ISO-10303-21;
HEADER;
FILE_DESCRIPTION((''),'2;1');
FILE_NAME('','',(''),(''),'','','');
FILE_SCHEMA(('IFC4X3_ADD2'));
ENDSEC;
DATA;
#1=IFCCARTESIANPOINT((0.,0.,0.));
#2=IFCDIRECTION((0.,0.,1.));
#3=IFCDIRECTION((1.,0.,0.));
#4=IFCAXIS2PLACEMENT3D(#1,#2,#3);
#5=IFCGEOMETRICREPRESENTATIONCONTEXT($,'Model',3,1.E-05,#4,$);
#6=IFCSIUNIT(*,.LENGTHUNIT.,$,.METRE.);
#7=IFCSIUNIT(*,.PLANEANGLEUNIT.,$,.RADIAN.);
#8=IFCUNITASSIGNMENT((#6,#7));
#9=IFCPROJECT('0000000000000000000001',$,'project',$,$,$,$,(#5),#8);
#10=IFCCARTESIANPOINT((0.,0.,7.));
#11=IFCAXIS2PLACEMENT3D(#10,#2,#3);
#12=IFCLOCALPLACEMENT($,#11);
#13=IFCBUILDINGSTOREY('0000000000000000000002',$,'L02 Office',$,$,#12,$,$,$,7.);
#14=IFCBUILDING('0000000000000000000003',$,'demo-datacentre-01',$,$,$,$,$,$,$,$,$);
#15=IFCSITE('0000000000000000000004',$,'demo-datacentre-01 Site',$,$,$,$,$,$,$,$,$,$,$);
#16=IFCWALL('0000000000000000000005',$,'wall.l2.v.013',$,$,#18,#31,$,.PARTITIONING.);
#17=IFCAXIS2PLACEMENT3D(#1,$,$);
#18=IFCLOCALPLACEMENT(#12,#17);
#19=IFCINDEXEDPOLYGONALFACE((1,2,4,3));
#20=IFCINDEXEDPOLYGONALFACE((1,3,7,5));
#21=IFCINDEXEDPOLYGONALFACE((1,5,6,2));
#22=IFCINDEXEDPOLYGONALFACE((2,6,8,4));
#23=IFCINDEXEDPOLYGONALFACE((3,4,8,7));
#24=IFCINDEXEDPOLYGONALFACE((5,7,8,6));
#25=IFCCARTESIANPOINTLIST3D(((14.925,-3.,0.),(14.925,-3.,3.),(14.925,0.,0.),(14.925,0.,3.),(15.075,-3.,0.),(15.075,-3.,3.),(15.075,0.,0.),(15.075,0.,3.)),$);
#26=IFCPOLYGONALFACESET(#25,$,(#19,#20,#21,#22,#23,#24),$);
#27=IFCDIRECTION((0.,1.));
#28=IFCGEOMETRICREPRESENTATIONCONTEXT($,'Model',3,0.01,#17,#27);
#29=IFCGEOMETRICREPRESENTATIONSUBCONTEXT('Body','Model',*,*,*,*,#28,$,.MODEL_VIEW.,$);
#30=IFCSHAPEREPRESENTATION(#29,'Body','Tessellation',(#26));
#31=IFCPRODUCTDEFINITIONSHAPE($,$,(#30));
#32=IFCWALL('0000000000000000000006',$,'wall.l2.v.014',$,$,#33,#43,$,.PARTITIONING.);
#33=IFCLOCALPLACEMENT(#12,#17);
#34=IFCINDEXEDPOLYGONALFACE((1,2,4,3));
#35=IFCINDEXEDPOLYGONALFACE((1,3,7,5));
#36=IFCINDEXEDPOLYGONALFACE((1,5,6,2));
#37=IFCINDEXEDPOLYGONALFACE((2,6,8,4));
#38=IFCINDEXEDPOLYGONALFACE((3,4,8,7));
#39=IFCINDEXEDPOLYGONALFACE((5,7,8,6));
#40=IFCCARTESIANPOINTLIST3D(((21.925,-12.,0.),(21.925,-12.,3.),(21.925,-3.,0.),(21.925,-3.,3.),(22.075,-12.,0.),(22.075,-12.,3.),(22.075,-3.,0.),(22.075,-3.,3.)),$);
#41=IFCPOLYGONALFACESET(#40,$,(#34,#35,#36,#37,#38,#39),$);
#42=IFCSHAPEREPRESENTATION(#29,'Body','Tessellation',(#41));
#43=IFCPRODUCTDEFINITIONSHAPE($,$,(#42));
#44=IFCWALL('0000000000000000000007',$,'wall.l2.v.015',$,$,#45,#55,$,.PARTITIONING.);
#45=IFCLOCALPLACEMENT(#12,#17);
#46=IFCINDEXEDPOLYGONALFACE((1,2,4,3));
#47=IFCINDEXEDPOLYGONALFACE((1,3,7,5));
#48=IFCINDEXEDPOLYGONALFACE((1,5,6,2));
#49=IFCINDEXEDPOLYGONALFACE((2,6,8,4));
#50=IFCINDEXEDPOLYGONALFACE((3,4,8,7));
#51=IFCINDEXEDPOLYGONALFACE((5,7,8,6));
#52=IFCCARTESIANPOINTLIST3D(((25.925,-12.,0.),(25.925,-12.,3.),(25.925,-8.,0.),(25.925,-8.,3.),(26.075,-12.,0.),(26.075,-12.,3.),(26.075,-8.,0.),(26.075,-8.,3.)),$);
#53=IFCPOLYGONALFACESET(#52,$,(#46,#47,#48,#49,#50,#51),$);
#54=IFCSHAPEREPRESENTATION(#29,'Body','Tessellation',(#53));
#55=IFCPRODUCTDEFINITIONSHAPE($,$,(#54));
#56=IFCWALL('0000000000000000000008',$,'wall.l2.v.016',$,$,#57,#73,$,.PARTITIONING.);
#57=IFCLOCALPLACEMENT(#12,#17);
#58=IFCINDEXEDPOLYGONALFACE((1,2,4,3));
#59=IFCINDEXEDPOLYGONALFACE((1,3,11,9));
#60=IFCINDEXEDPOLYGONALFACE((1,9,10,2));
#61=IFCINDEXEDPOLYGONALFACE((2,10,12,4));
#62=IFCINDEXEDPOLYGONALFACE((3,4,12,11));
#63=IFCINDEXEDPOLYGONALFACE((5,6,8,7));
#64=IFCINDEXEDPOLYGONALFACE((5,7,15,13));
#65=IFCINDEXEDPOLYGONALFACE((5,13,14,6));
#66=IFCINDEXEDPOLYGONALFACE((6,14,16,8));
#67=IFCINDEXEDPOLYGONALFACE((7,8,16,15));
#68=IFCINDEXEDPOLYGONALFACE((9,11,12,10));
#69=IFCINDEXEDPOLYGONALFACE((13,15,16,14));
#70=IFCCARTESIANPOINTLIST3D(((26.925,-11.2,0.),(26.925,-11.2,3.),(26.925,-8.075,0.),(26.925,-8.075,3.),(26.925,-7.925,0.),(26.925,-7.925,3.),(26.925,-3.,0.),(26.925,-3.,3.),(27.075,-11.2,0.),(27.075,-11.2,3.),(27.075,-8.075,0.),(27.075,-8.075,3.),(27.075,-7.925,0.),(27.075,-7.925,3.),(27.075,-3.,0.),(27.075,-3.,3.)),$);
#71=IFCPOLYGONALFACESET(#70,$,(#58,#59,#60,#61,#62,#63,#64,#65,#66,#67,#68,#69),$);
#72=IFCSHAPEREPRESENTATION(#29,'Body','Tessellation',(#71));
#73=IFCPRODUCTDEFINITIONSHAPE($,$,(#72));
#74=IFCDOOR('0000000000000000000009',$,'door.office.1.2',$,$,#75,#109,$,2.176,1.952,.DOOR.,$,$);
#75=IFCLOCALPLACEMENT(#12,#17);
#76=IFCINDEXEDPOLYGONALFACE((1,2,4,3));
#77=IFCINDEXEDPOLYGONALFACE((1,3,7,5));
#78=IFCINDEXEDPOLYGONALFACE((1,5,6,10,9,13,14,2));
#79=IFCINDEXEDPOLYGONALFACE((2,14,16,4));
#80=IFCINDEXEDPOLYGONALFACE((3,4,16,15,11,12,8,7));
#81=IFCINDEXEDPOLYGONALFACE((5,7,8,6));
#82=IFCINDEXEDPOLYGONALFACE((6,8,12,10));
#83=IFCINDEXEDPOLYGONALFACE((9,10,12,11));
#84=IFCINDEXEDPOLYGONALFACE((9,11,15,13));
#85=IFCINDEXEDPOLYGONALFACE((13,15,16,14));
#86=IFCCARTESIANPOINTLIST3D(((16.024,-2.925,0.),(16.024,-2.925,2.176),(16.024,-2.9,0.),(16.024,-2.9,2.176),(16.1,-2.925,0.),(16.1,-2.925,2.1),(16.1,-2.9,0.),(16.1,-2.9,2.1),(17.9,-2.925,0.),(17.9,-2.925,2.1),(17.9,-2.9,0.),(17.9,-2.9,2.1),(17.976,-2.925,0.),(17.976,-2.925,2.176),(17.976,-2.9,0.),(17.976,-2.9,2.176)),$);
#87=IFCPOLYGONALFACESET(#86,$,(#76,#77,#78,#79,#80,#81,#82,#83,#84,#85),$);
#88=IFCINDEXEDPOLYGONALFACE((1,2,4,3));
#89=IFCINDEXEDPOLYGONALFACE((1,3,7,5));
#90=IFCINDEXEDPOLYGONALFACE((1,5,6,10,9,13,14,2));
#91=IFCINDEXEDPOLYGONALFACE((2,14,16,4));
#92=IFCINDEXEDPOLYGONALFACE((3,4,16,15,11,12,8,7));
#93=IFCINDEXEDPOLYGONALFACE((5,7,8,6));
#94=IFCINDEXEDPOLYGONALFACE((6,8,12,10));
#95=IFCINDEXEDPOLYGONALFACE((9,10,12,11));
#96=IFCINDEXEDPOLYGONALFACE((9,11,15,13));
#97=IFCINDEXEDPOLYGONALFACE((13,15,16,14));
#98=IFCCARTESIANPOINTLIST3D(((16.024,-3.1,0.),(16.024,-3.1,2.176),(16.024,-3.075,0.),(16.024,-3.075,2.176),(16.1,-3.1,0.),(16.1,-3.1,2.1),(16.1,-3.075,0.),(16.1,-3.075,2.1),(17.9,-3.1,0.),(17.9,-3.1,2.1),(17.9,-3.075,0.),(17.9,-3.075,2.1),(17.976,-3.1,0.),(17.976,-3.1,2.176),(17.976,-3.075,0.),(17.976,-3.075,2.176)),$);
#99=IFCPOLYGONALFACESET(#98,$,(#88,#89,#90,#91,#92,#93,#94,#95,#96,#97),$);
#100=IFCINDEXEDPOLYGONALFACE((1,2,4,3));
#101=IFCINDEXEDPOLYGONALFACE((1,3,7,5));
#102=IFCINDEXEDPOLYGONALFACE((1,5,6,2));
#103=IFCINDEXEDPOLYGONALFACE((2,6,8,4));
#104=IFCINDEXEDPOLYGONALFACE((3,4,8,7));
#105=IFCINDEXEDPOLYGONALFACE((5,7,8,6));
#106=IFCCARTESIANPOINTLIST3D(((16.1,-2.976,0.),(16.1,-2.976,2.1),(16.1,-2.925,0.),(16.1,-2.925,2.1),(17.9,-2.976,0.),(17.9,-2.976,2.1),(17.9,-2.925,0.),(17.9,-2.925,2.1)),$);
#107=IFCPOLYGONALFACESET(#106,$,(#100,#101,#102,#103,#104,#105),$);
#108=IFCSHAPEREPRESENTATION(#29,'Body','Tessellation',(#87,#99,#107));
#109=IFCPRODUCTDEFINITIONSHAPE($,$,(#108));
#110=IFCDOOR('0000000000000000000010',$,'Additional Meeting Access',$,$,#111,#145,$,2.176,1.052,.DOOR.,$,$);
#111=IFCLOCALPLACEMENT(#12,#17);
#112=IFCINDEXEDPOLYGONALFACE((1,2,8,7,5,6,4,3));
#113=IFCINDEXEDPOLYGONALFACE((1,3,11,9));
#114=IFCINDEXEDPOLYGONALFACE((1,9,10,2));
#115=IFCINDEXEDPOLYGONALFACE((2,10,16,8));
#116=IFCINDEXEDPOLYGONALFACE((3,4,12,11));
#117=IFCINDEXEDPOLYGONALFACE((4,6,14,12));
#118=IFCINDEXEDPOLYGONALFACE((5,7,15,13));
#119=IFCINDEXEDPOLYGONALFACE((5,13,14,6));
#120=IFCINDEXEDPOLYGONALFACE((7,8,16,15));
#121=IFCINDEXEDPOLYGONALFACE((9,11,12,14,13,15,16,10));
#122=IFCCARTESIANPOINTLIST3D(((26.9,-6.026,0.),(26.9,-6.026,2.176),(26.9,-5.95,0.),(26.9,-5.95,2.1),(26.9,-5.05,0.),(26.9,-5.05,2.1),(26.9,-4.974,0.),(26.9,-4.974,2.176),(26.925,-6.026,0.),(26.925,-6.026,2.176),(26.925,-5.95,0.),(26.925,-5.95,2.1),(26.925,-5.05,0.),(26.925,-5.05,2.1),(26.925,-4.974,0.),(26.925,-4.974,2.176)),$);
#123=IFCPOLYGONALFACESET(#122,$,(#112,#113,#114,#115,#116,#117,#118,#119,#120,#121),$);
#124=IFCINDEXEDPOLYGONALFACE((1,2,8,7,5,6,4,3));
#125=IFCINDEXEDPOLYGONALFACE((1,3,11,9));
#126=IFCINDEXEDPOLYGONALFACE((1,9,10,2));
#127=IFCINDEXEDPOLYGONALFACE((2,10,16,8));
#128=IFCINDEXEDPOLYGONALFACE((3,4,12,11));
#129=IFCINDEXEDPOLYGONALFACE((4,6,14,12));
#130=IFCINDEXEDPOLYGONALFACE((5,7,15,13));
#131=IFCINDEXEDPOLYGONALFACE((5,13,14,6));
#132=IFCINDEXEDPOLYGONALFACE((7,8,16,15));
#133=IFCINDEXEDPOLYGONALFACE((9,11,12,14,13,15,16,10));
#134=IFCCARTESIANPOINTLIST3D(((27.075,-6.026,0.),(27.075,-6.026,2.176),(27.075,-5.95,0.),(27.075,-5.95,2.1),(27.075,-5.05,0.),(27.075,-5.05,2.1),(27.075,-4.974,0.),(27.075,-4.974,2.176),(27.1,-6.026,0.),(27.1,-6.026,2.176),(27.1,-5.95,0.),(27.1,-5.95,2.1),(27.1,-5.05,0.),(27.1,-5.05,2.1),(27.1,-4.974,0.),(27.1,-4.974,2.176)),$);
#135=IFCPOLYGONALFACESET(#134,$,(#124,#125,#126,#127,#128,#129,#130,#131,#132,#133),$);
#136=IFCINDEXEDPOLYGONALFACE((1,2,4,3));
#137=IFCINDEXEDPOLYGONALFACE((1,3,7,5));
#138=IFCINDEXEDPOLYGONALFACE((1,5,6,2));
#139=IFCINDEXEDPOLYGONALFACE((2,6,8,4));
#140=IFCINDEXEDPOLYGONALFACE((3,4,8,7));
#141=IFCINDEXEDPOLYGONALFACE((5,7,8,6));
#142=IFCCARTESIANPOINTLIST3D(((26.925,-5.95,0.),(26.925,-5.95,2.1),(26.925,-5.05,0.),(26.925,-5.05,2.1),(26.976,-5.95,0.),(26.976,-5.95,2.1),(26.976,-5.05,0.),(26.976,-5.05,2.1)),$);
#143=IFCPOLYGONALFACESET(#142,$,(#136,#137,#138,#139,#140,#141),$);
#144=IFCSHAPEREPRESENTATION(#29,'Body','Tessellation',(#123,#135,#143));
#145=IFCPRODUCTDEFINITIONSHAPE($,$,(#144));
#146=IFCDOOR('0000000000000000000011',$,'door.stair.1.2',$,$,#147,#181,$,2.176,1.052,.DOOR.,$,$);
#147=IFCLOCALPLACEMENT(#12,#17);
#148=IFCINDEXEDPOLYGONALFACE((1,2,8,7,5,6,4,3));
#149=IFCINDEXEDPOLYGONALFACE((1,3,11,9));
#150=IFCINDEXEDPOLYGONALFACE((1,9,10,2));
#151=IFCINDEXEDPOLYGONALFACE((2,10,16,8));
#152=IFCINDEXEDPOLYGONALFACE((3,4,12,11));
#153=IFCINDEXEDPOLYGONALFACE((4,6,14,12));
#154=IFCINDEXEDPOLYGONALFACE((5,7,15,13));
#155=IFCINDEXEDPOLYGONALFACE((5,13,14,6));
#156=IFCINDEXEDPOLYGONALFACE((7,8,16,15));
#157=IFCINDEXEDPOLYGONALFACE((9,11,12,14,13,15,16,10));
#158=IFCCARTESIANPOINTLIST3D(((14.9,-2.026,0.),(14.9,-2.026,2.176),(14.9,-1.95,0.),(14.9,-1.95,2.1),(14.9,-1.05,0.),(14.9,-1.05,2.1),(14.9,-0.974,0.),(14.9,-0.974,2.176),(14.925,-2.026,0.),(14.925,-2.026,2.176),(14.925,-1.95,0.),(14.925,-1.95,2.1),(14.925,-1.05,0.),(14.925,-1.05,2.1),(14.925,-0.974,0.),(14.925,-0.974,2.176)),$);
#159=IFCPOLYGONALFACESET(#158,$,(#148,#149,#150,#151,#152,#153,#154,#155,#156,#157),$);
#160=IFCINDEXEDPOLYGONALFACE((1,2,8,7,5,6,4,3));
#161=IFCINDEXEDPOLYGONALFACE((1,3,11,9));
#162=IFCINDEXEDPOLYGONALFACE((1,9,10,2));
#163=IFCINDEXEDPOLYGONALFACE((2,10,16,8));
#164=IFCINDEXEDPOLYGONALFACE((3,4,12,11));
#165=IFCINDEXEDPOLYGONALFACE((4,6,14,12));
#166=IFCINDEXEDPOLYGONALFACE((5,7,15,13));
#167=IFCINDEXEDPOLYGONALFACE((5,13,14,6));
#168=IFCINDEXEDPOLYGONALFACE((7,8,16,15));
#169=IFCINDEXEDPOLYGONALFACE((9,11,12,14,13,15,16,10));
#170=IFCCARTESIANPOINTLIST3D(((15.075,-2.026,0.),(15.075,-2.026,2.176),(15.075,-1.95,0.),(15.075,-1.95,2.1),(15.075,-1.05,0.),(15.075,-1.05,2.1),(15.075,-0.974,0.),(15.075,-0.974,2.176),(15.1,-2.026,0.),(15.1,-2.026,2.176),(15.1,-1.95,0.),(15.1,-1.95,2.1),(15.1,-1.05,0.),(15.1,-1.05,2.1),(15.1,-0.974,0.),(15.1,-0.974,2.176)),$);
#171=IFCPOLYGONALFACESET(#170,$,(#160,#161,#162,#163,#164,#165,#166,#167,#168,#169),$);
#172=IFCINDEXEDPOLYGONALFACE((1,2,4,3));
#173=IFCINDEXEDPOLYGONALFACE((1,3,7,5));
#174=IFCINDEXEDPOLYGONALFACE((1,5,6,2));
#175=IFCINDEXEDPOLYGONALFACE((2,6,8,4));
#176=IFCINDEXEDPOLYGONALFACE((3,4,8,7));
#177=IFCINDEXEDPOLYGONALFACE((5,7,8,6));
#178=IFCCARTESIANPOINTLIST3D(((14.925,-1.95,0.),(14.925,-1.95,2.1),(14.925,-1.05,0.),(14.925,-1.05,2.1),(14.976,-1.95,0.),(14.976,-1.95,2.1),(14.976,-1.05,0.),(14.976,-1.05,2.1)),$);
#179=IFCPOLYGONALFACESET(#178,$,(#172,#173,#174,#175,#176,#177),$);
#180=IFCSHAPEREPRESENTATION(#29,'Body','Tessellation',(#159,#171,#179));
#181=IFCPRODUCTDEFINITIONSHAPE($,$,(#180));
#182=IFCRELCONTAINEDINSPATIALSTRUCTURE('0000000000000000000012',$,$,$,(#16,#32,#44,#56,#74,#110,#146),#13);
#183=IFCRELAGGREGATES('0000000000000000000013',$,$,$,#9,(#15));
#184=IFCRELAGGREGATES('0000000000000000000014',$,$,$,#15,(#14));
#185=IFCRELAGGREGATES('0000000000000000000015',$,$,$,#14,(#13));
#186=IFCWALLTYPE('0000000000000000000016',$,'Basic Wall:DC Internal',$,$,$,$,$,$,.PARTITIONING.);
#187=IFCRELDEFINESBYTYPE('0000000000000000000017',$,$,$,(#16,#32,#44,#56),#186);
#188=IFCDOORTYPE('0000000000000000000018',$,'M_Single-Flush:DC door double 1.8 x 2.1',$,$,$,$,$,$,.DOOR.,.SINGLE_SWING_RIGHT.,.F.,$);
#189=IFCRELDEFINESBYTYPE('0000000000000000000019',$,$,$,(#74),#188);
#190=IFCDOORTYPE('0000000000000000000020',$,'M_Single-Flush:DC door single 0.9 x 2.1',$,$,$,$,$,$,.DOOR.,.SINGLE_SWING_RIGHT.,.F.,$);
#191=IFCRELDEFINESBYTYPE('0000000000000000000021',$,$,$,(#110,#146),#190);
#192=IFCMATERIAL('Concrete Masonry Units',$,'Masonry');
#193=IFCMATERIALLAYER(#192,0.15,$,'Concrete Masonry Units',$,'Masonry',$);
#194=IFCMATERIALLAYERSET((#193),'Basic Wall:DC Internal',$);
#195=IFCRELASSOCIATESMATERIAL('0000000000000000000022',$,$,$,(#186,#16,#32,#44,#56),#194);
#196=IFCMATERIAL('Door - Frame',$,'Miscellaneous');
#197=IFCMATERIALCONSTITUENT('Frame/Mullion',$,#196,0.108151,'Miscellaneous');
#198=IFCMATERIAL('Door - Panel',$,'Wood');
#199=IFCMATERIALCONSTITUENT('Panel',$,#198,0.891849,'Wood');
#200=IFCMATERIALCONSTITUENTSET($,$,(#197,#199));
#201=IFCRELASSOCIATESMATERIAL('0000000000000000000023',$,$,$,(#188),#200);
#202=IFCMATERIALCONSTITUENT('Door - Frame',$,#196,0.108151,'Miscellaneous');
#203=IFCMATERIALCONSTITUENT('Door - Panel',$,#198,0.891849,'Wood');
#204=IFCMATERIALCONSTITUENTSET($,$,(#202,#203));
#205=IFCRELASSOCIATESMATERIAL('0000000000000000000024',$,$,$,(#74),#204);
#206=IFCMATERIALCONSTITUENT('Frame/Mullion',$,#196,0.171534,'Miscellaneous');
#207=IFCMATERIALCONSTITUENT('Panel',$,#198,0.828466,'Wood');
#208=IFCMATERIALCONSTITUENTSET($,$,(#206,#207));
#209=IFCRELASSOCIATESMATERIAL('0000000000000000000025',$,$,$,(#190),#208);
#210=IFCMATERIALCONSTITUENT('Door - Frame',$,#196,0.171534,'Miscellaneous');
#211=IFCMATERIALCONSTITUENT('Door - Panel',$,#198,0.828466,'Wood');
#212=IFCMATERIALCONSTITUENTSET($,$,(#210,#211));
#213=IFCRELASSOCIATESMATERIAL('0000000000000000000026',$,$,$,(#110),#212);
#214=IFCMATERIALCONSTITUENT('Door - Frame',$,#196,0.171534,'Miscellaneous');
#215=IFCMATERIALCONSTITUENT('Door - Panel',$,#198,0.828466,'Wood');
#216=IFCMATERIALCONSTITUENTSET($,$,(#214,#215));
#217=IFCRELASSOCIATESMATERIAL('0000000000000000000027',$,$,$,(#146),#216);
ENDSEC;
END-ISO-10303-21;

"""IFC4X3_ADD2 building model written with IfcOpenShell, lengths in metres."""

from ifc_helpers import new_model, si_unit, direction, frame, frame_2d, origin, origin_with_axes, place, context, subcontext, project, spatial, polyline, rectangle, outline, extrude, source, transform, mapped, material, layer, layer_set, constituent, constituent_set, type_object, type_shapes, element, save


model = new_model("IFC4X3_ADD2")

# Units and contexts
model_context_1 = context("Model", 3, precision=0.01, world=origin(), true_north=direction((0.0, 1.0)))
model_context_2 = context("Model", 3, precision=1e-05, world=origin_with_axes())
body_context = subcontext(model_context_1, "Body", "Model", "MODEL_VIEW")
ifc_project = project(units=[si_unit("LENGTHUNIT", "METRE"), si_unit("PLANEANGLEUNIT", "RADIAN")], contexts=[model_context_2])

# Site, building, storey
site = spatial("IfcSite", under=ifc_project, Name="demo-datacentre-01 Site")
building = spatial("IfcBuilding", under=site, Name="demo-datacentre-01")
storey_placement = place(None, frame((0.0, 0.0, 7.0), z_axis=(0.0, 0.0, 1.0), x_axis=(1.0, 0.0, 0.0)))
storey = spatial("IfcBuildingStorey", under=building, at=storey_placement, Name="L02 Office", Elevation=7.0)

# Shared definitions
placement_1 = place(None, origin())
placement_2 = place(placement_1, origin())
placement_3 = place(placement_2, frame((0.0, 0.0, 7.0)))

# Walls
ifc_material_1 = material(Name="Concrete Masonry Units", Category="Masonry")
ifc_layer_1 = layer(ifc_material_1, 0.15, Name="Concrete Masonry Units", Category="Masonry")
ifc_layer_set_1 = layer_set([ifc_layer_1], Name="Basic Wall:DC Internal")
wall_type_1 = type_object("IfcWallType", Name="Basic Wall:DC Internal", PredefinedType="PARTITIONING", material=ifc_layer_set_1)
wall_1_placement = place(placement_3, frame((15.0, -3.0, 0.0), z_axis=(0.0, 0.0, 1.0), x_axis=(0.0, 1.0, 0.0)))
element("IfcWall", 1, at=wall_1_placement, inside=storey, type_object=wall_type_1, material=ifc_layer_set_1, Name="wall.l2.v.013", PredefinedType="PARTITIONING", context=body_context, shape_type="SweptSolid", body=[
    extrude(rectangle(XDim=3.0, YDim=0.15, at=frame_2d((1.5, 0.0), x_axis=(-1.0, 0.0))), origin(), (0.0, 0.0, 1.0), 3.0),
])
wall_2_placement = place(placement_3, frame((22.0, -12.0, 0.0), z_axis=(0.0, 0.0, 1.0), x_axis=(0.0, 1.0, 0.0)))
element("IfcWall", 2, at=wall_2_placement, inside=storey, type_object=wall_type_1, material=ifc_layer_set_1, Name="wall.l2.v.014", PredefinedType="PARTITIONING", context=body_context, shape_type="SweptSolid", body=[
    extrude(rectangle(XDim=9.0, YDim=0.15, at=frame_2d((4.5, 0.0), x_axis=(-1.0, 0.0))), origin(), (0.0, 0.0, 1.0), 3.0),
])
wall_3_placement = place(placement_3, frame((26.0, -12.0, 0.0), z_axis=(0.0, 0.0, 1.0), x_axis=(0.0, 1.0, 0.0)))
element("IfcWall", 3, at=wall_3_placement, inside=storey, type_object=wall_type_1, material=ifc_layer_set_1, Name="wall.l2.v.015", PredefinedType="PARTITIONING", context=body_context, shape_type="SweptSolid", body=[
    extrude(rectangle(XDim=4.0, YDim=0.15, at=frame_2d((2.0, 0.0), x_axis=(-1.0, 0.0))), origin(), (0.0, 0.0, 1.0), 3.0),
])

# Wall, opening
wall_4_placement = place(placement_3, frame((27.0, -11.2, 0.0), z_axis=(0.0, 0.0, 1.0), x_axis=(0.0, 1.0, 0.0)))
wall_4 = element("IfcWall", 4, at=wall_4_placement, inside=storey, type_object=wall_type_1, material=ifc_layer_set_1, Name="wall.l2.v.016", PredefinedType="PARTITIONING", context=body_context, shape_type="SweptSolid", body=[
    extrude(rectangle(XDim=8.2, YDim=0.15, at=frame_2d((4.1, 0.0), x_axis=(-1.0, 0.0))), origin(), (0.0, 0.0, 1.0), 3.0),
])
opening_placement = place(placement_3, frame((27.0, -11.2, 0.0), z_axis=(0.0, 0.0, 1.0), x_axis=(0.0, 1.0, 0.0)))
element("IfcOpeningElement", 5, at=opening_placement, cuts=wall_4, PredefinedType="OPENING", context=body_context, shape_type="SweptSolid", body=[
    extrude(rectangle(XDim=3.0, YDim=0.15, at=frame_2d((0.0, 0.0), x_axis=(1.0, 0.0))), frame((3.125, 0.0, 1.5), z_axis=(1.0, 0.0, 0.0), x_axis=(0.0, 0.0, -1.0)), (0.0, 0.0, 1.0), 0.15),
])

# Doors
ifc_material_2 = material(Name="Door - Frame", Category="Miscellaneous")
ifc_constituent_1 = constituent(ifc_material_2, Name="Door - Frame", Category="Miscellaneous", fraction=0.108151)
ifc_material_3 = material(Name="Door - Panel", Category="Wood")
ifc_constituent_2 = constituent(ifc_material_3, Name="Door - Panel", Category="Wood", fraction=0.891849)
ifc_constituent_set_1 = constituent_set(constituents=[ifc_constituent_1, ifc_constituent_2])
ifc_constituent_3 = constituent(ifc_material_2, Name="Frame/Mullion", Category="Miscellaneous", fraction=0.108151)
ifc_constituent_4 = constituent(ifc_material_3, Name="Panel", Category="Wood", fraction=0.891849)
ifc_constituent_set_2 = constituent_set(constituents=[ifc_constituent_3, ifc_constituent_4])
door_type_1 = type_object("IfcDoorType", Name="M_Single-Flush:DC door double 1.8 x 2.1", OperationType="SINGLE_SWING_RIGHT", ParameterTakesPrecedence=False, PredefinedType="DOOR", material=ifc_constituent_set_2)
shared_shape_1 = source(origin(), body_context, "Body", "SweptSolid", [
    extrude(outline(polyline([(-0.976, -1.107), (0.976, -1.107), (0.976, 1.069), (0.9, 1.069), (0.9, -1.031), (-0.9, -1.031), (-0.9, 1.069), (-0.976, 1.069), (-0.976, -1.107)])), frame((0.9, 0.15, 1.069), z_axis=(0.0, 1.0, 0.0), x_axis=(1.0, 0.0, 0.0)), (0.0, 0.0, 1.0), 0.025),
    extrude(outline(polyline([(-1.107, -0.976), (1.069, -0.976), (1.069, -0.9), (-1.031, -0.9), (-1.031, 0.9), (1.069, 0.9), (1.069, 0.976), (-1.107, 0.976), (-1.107, -0.976)])), frame((0.9, -0.025, 1.069), z_axis=(0.0, 1.0, 0.0), x_axis=(0.0, 0.0, -1.0)), (0.0, 0.0, 1.0), 0.025),
    extrude(rectangle(XDim=0.051, YDim=1.8, at=frame_2d((0.0, 0.0), x_axis=(1.0, 0.0))), frame((0.9, 0.1245, 0.0), z_axis=(0.0, 0.0, 1.0), x_axis=(0.0, 1.0, 0.0)), (0.0, 0.0, 1.0), 2.1),
])
type_shapes(door_type_1, [shared_shape_1])
door_1_placement = place(placement_3, frame((16.1, -3.075, 0.0)))
element("IfcDoor", 6, at=door_1_placement, inside=storey, type_object=door_type_1, material=ifc_constituent_set_1, Name="door.office.1.2", OverallHeight=2.176, OverallWidth=1.952, PredefinedType="DOOR", context=body_context, shape_type="MappedRepresentation", body=[
    mapped(shared_shape_1, transform((0.0, 0.0, 0.0), scale=1.0)),
])
ifc_constituent_5 = constituent(ifc_material_2, Name="Door - Frame", Category="Miscellaneous", fraction=0.171534)
ifc_constituent_6 = constituent(ifc_material_3, Name="Door - Panel", Category="Wood", fraction=0.828466)
ifc_constituent_set_3 = constituent_set(constituents=[ifc_constituent_5, ifc_constituent_6])
ifc_constituent_7 = constituent(ifc_material_2, Name="Frame/Mullion", Category="Miscellaneous", fraction=0.171534)
ifc_constituent_8 = constituent(ifc_material_3, Name="Panel", Category="Wood", fraction=0.828466)
ifc_constituent_set_4 = constituent_set(constituents=[ifc_constituent_7, ifc_constituent_8])
door_type_2 = type_object("IfcDoorType", Name="M_Single-Flush:DC door single 0.9 x 2.1", OperationType="SINGLE_SWING_RIGHT", ParameterTakesPrecedence=False, PredefinedType="DOOR", material=ifc_constituent_set_4)
shared_shape_2 = source(origin(), body_context, "Body", "SweptSolid", [
    extrude(outline(polyline([(-0.526, -1.107), (0.526, -1.107), (0.526, 1.069), (0.45, 1.069), (0.45, -1.031), (-0.45, -1.031), (-0.45, 1.069), (-0.526, 1.069), (-0.526, -1.107)])), frame((0.45, 0.15, 1.069), z_axis=(0.0, 1.0, 0.0), x_axis=(1.0, 0.0, 0.0)), (0.0, 0.0, 1.0), 0.025),
    extrude(outline(polyline([(-1.107, -0.526), (1.069, -0.526), (1.069, -0.45), (-1.031, -0.45), (-1.031, 0.45), (1.069, 0.45), (1.069, 0.526), (-1.107, 0.526), (-1.107, -0.526)])), frame((0.45, -0.025, 1.069), z_axis=(0.0, 1.0, 0.0), x_axis=(0.0, 0.0, -1.0)), (0.0, 0.0, 1.0), 0.025),
    extrude(rectangle(XDim=0.051, YDim=0.9, at=frame_2d((0.0, 0.0), x_axis=(1.0, 0.0))), frame((0.45, 0.1245, 0.0), z_axis=(0.0, 0.0, 1.0), x_axis=(0.0, 1.0, 0.0)), (0.0, 0.0, 1.0), 2.1),
])
type_shapes(door_type_2, [shared_shape_2])
door_2_placement = place(placement_3, frame((27.075, -5.95, 0.0), z_axis=(0.0, 0.0, 1.0), x_axis=(0.0, 1.0, 0.0)))
element("IfcDoor", 7, at=door_2_placement, inside=storey, type_object=door_type_2, material=ifc_constituent_set_3, Name="Additional Meeting Access", OverallHeight=2.176, OverallWidth=1.052, PredefinedType="DOOR", context=body_context, shape_type="MappedRepresentation", body=[
    mapped(shared_shape_2, transform((0.0, 0.0, 0.0), scale=1.0)),
])
ifc_constituent_9 = constituent(ifc_material_2, Name="Door - Frame", Category="Miscellaneous", fraction=0.171534)
ifc_constituent_10 = constituent(ifc_material_3, Name="Door - Panel", Category="Wood", fraction=0.828466)
ifc_constituent_set_5 = constituent_set(constituents=[ifc_constituent_9, ifc_constituent_10])
door_3_placement = place(placement_3, frame((15.075, -1.95, 0.0), z_axis=(0.0, 0.0, 1.0), x_axis=(0.0, 1.0, 0.0)))
element("IfcDoor", 8, at=door_3_placement, inside=storey, type_object=door_type_2, material=ifc_constituent_set_5, Name="door.stair.1.2", OverallHeight=2.176, OverallWidth=1.052, PredefinedType="DOOR", context=body_context, shape_type="MappedRepresentation", body=[
    mapped(shared_shape_2, transform((0.0, 0.0, 0.0), scale=1.0)),
])

save(model, "model.ifc")
